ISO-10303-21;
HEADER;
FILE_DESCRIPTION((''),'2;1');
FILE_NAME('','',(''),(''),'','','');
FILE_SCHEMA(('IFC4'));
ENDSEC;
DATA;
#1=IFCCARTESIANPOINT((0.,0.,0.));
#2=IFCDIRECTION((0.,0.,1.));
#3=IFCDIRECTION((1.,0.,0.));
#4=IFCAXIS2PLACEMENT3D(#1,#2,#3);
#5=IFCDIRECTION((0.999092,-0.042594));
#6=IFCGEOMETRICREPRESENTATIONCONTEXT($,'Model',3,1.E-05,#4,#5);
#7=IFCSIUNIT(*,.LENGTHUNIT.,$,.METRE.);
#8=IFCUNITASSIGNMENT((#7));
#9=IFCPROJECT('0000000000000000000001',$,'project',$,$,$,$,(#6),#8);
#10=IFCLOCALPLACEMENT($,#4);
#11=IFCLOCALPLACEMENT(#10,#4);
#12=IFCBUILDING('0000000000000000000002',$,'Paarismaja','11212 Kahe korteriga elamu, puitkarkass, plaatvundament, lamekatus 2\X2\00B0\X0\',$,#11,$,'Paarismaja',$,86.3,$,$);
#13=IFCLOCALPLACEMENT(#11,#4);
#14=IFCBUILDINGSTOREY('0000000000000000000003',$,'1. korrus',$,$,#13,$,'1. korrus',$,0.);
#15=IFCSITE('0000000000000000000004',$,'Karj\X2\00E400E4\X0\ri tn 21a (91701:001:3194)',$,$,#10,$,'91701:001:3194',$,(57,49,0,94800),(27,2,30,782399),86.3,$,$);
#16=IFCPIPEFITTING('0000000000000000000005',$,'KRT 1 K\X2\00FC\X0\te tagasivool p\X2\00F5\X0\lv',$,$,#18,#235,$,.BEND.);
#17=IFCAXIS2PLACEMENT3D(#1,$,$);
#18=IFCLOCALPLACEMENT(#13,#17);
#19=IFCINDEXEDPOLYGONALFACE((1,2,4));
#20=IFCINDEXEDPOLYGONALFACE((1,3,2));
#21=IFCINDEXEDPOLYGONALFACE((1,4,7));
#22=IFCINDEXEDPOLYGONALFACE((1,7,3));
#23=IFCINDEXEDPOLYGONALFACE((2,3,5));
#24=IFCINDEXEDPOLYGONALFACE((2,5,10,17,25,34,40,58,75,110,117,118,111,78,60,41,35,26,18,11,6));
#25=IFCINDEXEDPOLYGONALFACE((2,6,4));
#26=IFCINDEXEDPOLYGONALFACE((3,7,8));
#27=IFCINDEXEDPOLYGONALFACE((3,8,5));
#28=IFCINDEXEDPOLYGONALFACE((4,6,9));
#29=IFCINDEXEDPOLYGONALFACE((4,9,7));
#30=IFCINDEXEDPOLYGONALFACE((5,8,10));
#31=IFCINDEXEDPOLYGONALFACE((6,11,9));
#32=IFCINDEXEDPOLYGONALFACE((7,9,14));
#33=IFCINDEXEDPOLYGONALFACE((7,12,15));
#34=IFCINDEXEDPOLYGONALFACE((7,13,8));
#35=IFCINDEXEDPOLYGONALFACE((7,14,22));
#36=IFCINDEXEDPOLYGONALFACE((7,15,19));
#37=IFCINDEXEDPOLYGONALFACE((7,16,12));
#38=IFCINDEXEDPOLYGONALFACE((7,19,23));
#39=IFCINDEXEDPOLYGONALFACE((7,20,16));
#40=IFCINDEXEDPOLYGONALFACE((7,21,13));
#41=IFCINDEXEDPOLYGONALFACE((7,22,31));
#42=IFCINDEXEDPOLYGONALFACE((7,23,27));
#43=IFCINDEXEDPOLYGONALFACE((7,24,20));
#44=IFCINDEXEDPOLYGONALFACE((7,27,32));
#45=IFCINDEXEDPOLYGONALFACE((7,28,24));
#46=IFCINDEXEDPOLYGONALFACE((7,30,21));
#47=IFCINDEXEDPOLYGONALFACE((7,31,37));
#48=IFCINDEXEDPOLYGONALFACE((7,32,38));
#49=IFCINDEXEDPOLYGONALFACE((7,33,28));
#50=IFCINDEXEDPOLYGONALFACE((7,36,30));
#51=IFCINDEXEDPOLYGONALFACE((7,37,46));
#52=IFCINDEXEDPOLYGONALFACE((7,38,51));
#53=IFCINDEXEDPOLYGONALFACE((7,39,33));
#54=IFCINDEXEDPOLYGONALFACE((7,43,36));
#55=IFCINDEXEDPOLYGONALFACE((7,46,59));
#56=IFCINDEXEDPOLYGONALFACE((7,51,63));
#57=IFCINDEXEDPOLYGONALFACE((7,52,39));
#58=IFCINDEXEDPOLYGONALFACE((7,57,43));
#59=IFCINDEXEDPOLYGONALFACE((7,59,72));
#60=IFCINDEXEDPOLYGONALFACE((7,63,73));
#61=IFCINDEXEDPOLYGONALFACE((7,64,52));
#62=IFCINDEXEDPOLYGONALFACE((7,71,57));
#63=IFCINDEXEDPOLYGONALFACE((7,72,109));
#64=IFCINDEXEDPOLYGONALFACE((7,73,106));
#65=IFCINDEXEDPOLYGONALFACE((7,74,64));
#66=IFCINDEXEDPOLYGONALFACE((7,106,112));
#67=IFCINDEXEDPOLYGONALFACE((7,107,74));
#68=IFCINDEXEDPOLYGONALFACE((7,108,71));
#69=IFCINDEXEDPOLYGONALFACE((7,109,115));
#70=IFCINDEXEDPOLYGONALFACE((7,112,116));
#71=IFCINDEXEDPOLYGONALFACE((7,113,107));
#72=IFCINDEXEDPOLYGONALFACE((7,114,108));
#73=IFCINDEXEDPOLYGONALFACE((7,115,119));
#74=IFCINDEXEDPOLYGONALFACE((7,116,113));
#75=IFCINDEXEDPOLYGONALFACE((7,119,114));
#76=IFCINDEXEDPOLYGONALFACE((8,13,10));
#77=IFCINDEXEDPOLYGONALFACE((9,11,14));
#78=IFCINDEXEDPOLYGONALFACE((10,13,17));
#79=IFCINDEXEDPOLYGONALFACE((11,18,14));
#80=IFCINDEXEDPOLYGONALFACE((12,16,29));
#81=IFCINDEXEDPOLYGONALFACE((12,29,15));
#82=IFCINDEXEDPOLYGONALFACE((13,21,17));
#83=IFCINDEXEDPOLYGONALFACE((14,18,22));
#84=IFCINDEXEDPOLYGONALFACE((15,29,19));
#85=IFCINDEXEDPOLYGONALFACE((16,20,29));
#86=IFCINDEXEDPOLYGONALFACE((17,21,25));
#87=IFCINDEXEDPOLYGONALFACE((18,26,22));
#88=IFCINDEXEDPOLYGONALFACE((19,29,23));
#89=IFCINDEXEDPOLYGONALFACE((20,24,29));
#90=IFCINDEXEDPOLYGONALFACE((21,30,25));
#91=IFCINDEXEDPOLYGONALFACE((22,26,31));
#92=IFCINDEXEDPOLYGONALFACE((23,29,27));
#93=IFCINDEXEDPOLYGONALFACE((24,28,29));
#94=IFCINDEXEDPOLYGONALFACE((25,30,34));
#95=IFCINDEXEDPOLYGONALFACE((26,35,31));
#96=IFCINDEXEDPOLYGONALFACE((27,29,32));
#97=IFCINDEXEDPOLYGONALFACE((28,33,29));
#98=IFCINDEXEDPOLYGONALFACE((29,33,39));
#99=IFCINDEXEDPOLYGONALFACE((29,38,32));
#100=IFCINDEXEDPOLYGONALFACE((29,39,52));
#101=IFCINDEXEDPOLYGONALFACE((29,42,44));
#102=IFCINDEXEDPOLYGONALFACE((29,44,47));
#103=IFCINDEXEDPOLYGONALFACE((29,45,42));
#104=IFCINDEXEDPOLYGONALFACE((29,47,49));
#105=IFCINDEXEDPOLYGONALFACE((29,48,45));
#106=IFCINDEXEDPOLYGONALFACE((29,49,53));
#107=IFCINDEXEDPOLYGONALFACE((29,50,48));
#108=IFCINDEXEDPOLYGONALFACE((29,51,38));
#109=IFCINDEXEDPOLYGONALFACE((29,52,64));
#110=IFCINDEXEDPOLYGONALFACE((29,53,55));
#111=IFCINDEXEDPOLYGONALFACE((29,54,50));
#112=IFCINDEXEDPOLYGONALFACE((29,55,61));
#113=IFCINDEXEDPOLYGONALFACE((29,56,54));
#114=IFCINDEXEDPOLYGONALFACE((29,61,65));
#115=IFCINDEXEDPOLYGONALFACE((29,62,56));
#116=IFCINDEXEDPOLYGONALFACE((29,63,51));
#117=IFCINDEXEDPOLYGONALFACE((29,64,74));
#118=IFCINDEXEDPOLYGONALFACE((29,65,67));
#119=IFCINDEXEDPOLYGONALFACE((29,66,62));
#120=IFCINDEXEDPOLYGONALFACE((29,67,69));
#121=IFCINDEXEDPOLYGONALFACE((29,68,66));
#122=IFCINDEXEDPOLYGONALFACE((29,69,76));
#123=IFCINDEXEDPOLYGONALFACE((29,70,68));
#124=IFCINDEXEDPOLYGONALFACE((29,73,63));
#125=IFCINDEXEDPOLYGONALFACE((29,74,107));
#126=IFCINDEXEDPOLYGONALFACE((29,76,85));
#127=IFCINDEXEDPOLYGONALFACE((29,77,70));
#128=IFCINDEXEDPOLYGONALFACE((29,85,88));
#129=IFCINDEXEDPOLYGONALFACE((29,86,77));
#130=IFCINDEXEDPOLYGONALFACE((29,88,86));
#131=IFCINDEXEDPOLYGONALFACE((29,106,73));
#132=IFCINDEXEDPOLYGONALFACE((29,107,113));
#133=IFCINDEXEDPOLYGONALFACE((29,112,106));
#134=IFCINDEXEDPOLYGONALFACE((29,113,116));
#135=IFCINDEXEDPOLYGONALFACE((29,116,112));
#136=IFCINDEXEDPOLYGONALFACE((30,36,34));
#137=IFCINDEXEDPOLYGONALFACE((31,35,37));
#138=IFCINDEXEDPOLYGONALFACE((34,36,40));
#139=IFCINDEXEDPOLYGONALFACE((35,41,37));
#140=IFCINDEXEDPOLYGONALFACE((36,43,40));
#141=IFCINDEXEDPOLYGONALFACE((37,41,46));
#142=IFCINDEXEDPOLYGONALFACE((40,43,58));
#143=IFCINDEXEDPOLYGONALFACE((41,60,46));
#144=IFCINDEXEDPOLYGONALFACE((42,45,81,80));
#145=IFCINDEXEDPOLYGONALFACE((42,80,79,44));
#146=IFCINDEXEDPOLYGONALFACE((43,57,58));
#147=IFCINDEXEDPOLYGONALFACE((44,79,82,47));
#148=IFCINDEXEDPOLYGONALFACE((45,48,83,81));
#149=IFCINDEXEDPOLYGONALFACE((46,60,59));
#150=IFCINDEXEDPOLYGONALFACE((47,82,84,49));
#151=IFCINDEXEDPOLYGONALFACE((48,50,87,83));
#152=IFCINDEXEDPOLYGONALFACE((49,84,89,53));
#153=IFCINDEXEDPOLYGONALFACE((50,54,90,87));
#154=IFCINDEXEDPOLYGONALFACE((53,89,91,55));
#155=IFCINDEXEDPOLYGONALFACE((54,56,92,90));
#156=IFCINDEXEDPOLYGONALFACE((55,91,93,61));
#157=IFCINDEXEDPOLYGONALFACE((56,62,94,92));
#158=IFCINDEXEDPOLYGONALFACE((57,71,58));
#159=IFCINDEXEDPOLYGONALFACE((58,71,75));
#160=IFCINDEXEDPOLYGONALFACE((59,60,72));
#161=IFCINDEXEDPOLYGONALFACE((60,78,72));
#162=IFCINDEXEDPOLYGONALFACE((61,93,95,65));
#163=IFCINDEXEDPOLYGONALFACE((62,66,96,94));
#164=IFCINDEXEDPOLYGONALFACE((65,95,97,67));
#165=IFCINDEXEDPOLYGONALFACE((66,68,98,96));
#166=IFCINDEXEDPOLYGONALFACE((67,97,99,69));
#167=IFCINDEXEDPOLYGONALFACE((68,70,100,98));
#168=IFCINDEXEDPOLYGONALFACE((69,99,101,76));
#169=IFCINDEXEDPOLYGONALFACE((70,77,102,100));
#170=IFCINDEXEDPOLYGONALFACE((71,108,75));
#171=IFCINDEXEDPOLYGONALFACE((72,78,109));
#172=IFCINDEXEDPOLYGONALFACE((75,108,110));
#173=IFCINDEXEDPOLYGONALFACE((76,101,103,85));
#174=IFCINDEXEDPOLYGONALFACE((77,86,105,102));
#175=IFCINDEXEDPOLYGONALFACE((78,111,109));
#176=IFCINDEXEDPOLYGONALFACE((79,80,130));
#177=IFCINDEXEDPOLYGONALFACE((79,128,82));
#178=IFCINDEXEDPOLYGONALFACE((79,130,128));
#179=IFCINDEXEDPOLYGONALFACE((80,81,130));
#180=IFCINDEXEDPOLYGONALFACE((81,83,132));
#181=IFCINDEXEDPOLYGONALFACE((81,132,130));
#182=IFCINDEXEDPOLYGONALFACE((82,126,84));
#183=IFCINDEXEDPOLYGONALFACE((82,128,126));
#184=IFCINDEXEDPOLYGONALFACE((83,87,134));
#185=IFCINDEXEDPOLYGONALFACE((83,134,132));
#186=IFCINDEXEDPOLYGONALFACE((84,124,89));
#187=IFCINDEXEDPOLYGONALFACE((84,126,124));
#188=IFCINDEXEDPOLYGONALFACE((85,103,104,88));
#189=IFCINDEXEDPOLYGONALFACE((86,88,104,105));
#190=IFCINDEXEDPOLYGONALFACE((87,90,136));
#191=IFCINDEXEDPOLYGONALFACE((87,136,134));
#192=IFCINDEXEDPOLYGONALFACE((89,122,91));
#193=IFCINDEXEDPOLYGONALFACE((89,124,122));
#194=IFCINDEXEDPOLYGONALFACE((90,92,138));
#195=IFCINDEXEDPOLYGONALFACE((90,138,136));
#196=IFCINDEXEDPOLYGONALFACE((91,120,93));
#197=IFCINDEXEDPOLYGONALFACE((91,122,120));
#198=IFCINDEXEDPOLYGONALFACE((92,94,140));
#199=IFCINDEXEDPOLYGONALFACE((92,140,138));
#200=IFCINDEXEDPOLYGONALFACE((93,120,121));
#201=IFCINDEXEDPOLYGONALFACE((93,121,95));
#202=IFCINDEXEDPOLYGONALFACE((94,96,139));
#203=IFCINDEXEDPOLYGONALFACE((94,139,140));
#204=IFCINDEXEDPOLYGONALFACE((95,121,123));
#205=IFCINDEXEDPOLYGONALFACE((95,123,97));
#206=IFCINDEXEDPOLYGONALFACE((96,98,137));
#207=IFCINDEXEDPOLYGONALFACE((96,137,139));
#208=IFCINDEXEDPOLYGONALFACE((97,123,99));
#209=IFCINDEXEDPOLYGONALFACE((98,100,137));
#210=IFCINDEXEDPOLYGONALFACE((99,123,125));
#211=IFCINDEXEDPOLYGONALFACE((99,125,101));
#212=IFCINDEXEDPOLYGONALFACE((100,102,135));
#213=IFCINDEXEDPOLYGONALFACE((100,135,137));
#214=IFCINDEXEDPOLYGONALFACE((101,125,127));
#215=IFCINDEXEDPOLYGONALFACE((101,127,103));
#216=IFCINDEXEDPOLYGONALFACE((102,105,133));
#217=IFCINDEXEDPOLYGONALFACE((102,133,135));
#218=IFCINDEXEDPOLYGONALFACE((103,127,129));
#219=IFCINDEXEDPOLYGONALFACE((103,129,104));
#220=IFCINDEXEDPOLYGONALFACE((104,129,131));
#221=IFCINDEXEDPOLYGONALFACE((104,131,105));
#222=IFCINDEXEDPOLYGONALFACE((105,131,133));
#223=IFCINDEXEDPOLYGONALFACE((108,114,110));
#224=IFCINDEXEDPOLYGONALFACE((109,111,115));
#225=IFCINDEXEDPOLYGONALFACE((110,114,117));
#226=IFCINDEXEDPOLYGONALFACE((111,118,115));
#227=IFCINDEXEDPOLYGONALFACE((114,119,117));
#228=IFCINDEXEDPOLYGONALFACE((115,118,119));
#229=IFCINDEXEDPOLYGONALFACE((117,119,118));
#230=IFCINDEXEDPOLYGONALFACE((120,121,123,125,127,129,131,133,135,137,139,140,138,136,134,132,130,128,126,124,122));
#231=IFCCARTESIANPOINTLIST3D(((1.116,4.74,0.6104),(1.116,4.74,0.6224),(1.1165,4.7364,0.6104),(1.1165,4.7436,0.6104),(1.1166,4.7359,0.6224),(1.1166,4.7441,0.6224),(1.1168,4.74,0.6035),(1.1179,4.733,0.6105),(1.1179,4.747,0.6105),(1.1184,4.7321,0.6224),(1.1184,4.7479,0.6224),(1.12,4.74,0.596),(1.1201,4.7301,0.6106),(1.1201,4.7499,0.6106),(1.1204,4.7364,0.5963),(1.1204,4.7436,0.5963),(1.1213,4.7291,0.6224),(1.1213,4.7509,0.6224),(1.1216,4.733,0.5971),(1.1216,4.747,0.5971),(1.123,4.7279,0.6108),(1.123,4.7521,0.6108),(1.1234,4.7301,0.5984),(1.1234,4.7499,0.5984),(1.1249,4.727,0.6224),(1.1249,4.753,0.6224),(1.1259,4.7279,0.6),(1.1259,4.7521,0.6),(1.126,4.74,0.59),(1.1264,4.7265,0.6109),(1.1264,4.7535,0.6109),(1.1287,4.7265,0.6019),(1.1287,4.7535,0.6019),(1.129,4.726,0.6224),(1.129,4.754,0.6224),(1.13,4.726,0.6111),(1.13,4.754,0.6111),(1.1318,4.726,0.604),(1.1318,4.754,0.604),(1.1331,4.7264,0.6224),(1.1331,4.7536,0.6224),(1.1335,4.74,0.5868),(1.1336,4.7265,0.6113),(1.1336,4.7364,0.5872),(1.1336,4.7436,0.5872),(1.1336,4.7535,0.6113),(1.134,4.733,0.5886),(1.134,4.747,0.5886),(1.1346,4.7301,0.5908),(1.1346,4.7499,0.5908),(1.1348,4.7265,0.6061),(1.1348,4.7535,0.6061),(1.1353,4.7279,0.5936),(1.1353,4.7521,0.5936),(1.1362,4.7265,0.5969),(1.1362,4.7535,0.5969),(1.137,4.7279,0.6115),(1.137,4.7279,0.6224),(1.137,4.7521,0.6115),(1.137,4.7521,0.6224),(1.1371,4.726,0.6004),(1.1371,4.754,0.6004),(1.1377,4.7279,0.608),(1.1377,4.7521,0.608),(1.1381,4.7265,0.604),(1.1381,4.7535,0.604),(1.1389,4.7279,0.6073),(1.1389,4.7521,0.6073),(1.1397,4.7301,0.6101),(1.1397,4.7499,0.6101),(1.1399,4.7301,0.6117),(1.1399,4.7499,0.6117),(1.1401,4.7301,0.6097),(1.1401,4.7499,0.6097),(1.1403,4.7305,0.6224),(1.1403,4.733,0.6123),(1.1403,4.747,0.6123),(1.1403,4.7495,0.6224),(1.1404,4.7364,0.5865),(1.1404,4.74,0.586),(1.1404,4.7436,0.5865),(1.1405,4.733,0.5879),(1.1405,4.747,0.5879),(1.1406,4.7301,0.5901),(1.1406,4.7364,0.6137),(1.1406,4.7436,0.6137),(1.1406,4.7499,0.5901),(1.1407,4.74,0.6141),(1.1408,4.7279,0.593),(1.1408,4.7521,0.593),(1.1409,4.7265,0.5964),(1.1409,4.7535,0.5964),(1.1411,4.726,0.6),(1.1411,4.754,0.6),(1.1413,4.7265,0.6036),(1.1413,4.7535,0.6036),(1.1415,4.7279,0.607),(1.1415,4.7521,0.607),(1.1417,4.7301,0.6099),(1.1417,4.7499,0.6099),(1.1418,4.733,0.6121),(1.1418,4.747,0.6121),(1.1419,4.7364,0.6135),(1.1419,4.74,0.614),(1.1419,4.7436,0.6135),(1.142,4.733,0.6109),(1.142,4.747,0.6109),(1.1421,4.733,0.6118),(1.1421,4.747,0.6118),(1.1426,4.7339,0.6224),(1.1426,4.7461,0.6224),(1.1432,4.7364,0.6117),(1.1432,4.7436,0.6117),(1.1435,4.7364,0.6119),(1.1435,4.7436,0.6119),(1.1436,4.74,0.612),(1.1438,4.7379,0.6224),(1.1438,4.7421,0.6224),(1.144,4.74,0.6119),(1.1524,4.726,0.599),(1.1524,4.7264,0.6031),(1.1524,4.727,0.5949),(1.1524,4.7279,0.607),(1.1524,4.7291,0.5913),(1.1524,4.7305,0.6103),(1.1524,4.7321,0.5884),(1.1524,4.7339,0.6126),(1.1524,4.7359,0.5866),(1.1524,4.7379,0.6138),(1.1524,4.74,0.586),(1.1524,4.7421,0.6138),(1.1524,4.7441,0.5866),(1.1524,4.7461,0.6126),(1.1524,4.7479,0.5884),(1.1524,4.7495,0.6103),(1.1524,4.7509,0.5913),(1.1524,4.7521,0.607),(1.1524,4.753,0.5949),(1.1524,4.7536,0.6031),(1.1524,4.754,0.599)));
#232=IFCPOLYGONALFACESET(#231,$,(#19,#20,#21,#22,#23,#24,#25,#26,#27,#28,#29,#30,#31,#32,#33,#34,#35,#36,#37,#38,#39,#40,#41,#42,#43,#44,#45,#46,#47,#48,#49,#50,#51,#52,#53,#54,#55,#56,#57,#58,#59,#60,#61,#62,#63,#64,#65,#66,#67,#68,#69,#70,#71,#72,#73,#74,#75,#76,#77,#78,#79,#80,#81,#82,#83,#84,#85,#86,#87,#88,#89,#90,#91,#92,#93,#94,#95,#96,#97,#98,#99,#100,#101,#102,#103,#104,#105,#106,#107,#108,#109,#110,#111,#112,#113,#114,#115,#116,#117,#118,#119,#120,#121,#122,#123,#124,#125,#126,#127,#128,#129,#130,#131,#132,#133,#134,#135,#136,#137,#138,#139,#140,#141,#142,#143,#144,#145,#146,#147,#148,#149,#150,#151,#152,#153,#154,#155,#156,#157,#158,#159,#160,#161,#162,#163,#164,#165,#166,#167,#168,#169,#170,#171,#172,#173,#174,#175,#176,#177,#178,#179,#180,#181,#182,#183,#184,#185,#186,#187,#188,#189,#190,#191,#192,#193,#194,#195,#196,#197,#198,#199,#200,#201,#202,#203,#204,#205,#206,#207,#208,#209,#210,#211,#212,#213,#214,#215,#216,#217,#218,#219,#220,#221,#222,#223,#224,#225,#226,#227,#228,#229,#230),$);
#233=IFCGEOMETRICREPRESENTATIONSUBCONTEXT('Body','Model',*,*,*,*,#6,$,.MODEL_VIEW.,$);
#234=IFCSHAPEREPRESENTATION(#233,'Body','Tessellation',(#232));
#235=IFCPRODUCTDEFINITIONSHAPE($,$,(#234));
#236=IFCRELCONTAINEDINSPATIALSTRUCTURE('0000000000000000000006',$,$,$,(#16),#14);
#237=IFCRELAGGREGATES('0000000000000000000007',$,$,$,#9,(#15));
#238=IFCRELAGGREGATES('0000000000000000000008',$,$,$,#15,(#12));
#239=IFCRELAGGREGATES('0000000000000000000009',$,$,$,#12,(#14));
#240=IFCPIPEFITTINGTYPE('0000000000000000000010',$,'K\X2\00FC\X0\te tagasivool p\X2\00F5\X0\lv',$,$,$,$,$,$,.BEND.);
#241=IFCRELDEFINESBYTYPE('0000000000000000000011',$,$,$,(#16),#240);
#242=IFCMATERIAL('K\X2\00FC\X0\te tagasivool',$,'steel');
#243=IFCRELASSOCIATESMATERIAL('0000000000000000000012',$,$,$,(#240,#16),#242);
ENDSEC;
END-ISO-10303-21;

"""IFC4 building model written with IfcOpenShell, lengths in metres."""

from ifc_helpers import new_model, entity, si_unit, direction, frame, origin_with_axes, place, context, subcontext, project, spatial, material, type_object, element, save


model = new_model("IFC4")

# Units and contexts
model_context = context("Model", 3, precision=1e-05, world=origin_with_axes(), true_north=direction((0.999092, -0.042594)))
body_context = subcontext(model_context, "Body", "Model", "MODEL_VIEW")
ifc_project = project(units=[si_unit("LENGTHUNIT", "METRE")], contexts=[model_context])

# Site, building, storey
site_placement = place(None, origin_with_axes())
site = spatial("IfcSite", under=ifc_project, at=site_placement, Name="Karjääri tn 21a (91701:001:3194)", LongName="91701:001:3194", RefLatitude=(57, 49, 0, 94800), RefLongitude=(27, 2, 30, 782399), RefElevation=86.3)
building_placement = place(site_placement, origin_with_axes())
building = spatial("IfcBuilding", under=site, at=building_placement, Name="Paarismaja", Description="11212 Kahe korteriga elamu, puitkarkass, plaatvundament, lamekatus 2°", LongName="Paarismaja", ElevationOfRefHeight=86.3)
storey_placement = place(building_placement, origin_with_axes())
storey = spatial("IfcBuildingStorey", under=building, at=storey_placement, Name="1. korrus", LongName="1. korrus", Elevation=0.0)

# Pipe fitting
ifc_material_1 = material(Name="Küte tagasivool", Category="steel")
pipe_fitting_type_1 = type_object("IfcPipeFittingType", Name="Küte tagasivool põlv", PredefinedType="BEND", material=ifc_material_1)
pipe_fitting_1_placement = place(storey_placement, frame((1.13, 4.74, 0.6), z_axis=(0.0, 0.0, 1.0), x_axis=(1.0, 0.0, 0.0)))
element("IfcPipeFitting", 1, at=pipe_fitting_1_placement, inside=storey, type_object=pipe_fitting_type_1, material=ifc_material_1, Name="KRT 1 Küte tagasivool põlv", PredefinedType="BEND", context=body_context, shape_type="AdvancedSweptSolid", body=[
    entity("IfcSweptDiskSolid", entity("IfcIndexedPolyCurve", entity("IfcCartesianPointList3D", [[0.0224, 0.0, 0.0], [0.0111, 0.0, 0.0], [0.0071, 0.0, 0.0004], [0.004, 0.0, 0.0018], [0.0018, 0.0, 0.004], [0.0004, 0.0, 0.0071], [0.0, 0.0, 0.0111], [0.0, 0.0, 0.0224]]), None, False), 0.014),
])

save(model, "model.ifc")
